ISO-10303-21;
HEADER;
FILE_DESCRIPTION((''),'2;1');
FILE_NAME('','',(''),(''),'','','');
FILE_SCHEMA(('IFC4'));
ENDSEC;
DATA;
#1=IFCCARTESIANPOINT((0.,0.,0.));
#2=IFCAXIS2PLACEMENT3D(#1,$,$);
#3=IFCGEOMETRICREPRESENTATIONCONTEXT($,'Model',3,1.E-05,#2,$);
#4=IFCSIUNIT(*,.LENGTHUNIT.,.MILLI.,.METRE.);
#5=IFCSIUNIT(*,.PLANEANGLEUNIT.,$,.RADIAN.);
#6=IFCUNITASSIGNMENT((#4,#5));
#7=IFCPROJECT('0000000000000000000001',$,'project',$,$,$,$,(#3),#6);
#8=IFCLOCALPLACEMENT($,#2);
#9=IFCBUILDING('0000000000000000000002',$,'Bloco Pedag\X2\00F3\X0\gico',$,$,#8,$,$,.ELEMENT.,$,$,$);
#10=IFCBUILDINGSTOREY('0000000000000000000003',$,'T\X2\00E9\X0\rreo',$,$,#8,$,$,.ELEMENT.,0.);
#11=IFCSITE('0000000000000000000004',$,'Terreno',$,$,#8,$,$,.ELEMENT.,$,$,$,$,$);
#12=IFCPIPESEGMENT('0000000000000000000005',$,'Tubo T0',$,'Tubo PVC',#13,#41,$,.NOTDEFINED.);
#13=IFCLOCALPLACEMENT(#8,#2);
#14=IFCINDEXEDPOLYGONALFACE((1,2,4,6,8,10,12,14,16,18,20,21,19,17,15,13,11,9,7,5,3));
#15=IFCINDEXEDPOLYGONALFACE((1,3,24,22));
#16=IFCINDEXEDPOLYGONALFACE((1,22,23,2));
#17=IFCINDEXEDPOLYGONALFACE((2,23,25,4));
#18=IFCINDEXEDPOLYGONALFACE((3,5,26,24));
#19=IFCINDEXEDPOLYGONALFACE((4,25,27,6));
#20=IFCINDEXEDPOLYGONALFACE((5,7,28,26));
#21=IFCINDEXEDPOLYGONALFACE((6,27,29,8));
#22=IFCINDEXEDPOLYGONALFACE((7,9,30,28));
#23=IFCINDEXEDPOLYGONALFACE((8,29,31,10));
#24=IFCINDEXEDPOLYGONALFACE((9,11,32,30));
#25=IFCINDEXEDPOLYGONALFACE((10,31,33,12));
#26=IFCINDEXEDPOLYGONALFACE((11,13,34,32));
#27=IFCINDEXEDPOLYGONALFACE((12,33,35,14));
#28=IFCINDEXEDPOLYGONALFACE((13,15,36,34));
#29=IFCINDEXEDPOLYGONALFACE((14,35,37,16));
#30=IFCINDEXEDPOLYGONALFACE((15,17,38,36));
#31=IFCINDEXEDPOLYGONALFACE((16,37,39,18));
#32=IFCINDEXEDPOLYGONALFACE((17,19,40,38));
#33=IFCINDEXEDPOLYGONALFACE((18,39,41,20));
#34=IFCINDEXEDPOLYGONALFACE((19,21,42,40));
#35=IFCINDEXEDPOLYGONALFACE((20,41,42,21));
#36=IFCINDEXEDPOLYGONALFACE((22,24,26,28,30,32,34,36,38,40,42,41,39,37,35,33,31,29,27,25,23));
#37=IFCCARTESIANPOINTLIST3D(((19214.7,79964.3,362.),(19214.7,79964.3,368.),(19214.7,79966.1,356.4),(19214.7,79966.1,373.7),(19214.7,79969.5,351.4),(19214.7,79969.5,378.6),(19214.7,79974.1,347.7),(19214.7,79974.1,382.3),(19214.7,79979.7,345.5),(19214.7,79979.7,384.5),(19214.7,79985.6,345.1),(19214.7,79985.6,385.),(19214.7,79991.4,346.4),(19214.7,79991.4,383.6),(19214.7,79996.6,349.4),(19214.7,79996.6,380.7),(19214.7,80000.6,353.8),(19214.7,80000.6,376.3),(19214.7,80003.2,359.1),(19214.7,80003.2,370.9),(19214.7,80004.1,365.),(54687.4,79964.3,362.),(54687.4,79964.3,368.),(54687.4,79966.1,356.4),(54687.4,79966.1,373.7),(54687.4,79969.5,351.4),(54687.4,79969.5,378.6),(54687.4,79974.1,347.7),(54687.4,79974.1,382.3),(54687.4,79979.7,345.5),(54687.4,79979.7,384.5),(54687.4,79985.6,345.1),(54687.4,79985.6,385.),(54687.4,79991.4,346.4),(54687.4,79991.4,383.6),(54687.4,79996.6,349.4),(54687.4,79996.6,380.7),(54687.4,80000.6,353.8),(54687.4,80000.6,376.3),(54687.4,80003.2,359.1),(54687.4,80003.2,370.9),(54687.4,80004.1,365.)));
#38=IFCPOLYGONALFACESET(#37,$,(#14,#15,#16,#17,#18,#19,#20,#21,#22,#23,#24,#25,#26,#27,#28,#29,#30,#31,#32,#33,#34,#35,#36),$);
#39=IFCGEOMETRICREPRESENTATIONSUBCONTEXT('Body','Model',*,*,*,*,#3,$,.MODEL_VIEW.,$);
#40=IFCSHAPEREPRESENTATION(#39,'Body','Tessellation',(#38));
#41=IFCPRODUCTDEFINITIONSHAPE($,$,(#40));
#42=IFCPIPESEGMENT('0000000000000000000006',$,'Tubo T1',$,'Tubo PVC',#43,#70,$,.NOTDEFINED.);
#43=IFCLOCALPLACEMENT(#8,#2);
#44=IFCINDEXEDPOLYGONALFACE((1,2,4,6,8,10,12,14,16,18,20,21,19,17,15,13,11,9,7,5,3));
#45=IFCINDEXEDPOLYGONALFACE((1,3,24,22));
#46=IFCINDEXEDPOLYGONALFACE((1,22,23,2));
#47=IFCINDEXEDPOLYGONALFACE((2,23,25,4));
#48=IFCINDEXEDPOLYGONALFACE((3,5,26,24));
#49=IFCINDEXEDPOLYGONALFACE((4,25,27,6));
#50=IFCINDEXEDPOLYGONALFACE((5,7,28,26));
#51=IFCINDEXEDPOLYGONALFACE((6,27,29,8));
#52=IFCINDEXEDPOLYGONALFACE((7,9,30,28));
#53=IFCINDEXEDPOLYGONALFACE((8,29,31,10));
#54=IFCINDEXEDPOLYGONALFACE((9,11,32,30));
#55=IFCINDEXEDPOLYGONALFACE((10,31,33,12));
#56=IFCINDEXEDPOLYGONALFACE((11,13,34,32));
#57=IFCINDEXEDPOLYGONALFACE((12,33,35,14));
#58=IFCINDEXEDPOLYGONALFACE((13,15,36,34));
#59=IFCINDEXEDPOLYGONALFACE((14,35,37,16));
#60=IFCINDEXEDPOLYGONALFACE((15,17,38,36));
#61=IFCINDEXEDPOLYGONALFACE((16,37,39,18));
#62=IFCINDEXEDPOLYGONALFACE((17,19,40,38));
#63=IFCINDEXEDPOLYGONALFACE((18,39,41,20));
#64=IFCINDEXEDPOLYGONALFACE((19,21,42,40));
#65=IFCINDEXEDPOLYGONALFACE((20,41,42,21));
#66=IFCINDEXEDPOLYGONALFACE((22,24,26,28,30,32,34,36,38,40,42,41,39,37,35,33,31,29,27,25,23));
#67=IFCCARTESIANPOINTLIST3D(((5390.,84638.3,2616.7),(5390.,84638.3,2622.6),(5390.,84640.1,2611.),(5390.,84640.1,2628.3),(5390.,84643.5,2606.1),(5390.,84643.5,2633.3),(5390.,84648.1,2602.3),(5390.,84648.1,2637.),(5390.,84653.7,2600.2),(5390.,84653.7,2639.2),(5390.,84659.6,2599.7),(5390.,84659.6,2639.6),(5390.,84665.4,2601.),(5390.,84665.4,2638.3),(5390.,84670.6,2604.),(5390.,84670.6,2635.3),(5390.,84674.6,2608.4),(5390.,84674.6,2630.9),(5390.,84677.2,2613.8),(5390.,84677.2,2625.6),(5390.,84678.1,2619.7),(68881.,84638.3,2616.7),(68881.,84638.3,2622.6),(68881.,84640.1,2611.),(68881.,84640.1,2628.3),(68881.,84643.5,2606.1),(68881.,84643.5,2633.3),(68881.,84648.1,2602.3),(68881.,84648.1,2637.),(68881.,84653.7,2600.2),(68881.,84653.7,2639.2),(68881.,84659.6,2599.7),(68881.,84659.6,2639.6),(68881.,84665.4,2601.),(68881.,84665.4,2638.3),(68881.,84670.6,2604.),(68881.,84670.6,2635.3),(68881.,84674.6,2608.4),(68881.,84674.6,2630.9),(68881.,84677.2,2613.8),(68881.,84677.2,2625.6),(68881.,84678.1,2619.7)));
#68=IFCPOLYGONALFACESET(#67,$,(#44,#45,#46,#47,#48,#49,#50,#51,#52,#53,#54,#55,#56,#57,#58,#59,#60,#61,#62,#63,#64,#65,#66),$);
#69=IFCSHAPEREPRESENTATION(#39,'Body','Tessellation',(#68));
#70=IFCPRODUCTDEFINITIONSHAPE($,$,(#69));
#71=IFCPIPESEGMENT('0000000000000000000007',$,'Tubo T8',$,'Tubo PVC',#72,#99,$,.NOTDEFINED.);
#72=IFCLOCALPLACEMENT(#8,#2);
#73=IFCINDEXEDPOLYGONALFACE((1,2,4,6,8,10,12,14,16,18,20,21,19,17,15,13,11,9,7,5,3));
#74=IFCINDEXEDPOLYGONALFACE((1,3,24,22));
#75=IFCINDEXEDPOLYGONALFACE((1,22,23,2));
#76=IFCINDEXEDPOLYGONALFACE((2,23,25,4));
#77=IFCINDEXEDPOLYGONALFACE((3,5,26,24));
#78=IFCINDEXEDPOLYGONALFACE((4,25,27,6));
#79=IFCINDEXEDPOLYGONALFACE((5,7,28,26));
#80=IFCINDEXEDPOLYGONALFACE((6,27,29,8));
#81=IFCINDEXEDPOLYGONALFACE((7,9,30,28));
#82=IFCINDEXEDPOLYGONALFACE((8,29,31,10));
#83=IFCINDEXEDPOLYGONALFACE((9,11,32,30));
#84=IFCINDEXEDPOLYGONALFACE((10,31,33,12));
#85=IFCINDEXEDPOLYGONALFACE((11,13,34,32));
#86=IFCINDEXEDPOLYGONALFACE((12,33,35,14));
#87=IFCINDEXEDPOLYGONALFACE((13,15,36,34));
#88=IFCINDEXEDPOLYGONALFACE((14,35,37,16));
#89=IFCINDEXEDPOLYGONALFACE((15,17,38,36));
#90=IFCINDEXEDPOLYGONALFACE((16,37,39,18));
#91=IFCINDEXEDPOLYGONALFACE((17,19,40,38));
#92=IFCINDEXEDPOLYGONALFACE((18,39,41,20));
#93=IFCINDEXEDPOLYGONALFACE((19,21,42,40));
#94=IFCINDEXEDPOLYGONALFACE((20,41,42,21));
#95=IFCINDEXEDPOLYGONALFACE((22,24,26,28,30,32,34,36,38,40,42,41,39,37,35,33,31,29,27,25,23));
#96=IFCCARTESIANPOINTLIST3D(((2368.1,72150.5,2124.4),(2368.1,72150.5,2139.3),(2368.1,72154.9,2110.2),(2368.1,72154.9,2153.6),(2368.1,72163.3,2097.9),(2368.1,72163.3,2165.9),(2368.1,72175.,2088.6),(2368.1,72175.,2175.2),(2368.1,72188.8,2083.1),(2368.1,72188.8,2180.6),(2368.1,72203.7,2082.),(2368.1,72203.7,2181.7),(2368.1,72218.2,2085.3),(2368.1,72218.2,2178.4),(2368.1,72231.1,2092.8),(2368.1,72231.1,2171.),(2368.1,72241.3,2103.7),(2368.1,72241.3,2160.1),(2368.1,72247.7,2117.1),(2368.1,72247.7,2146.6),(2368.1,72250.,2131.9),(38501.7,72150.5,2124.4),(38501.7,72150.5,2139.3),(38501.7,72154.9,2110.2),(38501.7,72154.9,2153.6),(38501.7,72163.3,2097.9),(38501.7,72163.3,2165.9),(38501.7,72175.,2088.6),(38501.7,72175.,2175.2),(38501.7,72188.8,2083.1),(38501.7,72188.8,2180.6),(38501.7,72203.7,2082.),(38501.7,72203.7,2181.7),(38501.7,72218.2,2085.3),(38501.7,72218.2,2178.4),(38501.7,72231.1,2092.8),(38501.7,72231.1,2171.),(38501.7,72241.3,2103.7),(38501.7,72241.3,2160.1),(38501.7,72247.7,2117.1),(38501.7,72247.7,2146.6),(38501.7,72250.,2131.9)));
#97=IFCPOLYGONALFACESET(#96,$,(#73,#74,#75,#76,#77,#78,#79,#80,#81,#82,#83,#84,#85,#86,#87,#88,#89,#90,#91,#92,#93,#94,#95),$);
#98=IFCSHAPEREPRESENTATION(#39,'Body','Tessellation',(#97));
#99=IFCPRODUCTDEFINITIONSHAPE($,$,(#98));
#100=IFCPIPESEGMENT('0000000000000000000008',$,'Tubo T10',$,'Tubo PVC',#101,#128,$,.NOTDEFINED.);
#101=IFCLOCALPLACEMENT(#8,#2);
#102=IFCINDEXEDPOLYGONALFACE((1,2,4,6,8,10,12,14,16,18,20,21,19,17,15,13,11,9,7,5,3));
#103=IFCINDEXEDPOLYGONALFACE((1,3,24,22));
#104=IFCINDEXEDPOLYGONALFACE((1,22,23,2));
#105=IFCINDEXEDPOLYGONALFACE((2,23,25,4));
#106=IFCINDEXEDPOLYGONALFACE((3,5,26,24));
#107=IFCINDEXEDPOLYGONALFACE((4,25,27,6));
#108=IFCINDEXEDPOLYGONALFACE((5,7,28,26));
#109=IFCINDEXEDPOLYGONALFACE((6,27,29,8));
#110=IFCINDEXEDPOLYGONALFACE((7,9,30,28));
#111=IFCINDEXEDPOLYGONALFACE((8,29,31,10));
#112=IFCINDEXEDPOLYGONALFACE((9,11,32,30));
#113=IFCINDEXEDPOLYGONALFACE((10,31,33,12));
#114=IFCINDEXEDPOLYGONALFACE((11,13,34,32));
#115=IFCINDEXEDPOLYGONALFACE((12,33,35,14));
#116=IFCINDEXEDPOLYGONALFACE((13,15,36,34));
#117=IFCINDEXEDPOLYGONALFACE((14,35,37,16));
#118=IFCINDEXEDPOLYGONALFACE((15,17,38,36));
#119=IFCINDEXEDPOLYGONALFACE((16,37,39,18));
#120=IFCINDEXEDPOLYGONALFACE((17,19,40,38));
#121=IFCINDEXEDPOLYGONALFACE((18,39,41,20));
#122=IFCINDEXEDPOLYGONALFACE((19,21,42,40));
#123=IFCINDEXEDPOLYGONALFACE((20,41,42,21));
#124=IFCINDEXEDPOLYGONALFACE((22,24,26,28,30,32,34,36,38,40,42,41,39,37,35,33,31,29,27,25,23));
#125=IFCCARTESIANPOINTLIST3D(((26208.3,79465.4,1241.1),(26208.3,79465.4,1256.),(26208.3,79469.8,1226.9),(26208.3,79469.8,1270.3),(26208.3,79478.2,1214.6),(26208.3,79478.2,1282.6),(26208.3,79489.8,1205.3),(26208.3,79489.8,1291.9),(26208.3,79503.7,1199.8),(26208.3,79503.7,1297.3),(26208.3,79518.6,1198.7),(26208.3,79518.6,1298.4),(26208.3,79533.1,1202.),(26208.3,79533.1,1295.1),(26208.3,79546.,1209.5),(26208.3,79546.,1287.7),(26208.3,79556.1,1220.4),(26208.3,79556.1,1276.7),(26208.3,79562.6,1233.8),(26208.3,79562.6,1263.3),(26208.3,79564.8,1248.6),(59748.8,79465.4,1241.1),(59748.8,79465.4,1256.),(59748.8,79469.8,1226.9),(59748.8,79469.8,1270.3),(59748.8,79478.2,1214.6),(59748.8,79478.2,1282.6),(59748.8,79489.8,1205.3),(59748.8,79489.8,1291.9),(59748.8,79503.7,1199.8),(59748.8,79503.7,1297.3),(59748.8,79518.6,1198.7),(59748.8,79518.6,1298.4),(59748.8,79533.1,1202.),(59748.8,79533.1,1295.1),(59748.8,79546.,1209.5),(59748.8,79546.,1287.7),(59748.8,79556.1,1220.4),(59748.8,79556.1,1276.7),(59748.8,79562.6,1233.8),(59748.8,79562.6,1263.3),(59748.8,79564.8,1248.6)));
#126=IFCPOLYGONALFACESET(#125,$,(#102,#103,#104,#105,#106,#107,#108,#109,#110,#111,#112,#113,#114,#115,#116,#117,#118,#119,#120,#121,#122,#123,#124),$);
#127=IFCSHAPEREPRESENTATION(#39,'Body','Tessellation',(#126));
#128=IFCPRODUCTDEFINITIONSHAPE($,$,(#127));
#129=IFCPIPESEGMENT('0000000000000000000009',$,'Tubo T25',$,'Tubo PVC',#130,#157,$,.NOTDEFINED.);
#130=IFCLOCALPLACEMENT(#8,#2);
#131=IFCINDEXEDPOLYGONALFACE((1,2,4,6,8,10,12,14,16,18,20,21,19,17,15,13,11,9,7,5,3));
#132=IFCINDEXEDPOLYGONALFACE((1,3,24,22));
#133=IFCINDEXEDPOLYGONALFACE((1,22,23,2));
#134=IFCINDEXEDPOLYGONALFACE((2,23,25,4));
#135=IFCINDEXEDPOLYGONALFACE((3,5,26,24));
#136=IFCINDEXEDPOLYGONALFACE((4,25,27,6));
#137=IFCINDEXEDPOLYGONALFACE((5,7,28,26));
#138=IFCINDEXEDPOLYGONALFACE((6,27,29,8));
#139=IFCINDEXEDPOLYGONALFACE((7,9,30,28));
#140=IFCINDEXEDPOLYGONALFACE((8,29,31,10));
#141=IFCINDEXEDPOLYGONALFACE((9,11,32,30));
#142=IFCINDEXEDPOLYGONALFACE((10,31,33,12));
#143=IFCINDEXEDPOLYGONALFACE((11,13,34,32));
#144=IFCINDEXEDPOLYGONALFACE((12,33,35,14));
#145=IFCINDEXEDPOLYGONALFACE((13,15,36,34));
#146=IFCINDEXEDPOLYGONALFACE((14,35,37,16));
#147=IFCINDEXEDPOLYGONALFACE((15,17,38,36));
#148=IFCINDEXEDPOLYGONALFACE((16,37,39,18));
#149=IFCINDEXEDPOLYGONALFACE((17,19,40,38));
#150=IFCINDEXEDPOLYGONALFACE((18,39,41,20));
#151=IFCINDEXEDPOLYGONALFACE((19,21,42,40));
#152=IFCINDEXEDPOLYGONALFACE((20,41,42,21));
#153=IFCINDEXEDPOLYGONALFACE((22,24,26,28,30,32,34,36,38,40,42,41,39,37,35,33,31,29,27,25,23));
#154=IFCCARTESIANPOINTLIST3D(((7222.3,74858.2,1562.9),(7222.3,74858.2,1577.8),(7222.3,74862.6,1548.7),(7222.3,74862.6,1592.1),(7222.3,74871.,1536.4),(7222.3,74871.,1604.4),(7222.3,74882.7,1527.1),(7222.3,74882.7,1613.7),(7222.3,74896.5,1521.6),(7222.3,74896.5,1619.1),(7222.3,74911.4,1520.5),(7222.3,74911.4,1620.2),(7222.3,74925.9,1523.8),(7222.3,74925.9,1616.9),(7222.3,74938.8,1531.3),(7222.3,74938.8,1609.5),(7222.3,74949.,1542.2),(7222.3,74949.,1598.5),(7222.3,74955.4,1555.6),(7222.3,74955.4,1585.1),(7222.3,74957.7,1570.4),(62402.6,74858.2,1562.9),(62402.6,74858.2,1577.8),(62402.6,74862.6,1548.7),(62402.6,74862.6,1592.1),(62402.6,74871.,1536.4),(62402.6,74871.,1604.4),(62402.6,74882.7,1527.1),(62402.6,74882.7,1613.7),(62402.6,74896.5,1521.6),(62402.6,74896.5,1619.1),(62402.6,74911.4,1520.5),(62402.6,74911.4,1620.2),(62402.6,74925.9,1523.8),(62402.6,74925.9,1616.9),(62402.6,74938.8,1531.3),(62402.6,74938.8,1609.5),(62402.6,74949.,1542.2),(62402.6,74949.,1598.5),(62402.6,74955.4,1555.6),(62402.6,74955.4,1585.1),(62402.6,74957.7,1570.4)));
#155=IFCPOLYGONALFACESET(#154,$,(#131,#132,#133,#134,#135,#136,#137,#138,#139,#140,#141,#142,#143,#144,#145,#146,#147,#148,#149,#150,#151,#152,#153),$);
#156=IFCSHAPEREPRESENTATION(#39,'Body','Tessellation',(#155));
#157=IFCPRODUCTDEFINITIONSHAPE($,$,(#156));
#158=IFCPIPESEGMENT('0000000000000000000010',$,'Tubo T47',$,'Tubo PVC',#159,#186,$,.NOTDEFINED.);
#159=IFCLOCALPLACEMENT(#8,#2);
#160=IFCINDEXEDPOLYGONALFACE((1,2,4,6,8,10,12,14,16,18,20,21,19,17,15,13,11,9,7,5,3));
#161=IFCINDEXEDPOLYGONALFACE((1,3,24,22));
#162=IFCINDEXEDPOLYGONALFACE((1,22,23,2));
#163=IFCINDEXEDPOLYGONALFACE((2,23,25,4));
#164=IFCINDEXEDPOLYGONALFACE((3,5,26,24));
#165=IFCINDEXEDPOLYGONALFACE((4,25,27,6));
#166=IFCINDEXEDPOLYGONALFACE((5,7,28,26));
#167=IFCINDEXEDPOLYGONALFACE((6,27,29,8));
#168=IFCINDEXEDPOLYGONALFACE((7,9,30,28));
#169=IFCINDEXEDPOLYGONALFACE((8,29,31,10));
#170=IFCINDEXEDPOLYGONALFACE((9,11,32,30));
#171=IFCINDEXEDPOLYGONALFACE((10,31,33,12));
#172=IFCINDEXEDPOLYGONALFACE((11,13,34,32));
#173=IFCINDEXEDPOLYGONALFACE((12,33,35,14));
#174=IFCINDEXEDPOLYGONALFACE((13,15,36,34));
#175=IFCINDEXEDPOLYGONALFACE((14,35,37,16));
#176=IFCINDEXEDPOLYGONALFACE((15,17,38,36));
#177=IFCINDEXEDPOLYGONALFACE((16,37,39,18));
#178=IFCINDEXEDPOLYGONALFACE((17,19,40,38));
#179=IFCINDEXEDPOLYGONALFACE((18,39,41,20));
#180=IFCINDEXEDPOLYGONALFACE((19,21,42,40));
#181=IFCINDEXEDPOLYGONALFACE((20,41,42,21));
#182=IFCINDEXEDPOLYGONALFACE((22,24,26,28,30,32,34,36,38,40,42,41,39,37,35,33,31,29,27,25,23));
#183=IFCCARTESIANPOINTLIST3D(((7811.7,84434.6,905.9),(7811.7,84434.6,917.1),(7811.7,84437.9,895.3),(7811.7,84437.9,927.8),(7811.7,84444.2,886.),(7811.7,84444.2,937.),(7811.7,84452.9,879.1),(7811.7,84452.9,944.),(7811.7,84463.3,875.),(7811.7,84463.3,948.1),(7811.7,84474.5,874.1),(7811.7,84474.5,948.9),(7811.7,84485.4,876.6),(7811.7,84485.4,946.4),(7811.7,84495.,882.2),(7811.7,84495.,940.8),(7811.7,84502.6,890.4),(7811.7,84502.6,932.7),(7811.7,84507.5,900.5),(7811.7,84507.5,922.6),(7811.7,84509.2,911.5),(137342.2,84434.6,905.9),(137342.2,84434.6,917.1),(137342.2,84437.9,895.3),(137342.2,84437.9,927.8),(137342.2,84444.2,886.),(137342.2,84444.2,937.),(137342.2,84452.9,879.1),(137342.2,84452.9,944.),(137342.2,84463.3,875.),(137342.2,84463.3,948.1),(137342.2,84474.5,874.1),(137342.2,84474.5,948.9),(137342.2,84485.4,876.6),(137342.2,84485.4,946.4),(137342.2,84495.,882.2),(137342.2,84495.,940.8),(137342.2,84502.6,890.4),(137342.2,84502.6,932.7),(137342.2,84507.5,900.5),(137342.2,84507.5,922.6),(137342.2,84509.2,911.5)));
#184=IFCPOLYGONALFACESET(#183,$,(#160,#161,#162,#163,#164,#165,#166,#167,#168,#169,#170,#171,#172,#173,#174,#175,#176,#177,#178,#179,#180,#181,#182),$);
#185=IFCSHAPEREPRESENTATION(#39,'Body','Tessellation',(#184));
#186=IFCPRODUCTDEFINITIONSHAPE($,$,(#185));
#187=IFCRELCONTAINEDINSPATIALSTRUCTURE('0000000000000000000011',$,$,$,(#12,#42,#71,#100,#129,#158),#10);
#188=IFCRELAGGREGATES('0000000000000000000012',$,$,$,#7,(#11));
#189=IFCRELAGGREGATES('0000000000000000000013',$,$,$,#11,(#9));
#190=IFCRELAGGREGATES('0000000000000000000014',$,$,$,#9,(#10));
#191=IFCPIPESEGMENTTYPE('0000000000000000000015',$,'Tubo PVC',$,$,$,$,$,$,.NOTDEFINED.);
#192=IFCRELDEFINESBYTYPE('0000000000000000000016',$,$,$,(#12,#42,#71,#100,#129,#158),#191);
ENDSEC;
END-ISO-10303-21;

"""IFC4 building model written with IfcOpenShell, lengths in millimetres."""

from ifc_helpers import new_model, si_unit, frame, origin, origin_2d, place, context, subcontext, project, spatial, circle, extrude, type_object, element, save


model = new_model("IFC4")

# Units and contexts
model_context = context("Model", 3, precision=1e-05, world=origin())
body_context = subcontext(model_context, "Body", "Model", "MODEL_VIEW")
ifc_project = project(units=[si_unit("LENGTHUNIT", "METRE", prefix="MILLI"), si_unit("PLANEANGLEUNIT", "RADIAN")], contexts=[model_context])

# Site, building, storey
placement = place(None, origin())
site = spatial("IfcSite", under=ifc_project, at=placement, Name="Terreno", CompositionType="ELEMENT")
building = spatial("IfcBuilding", under=site, at=placement, Name="Bloco Pedagógico", CompositionType="ELEMENT")
storey = spatial("IfcBuildingStorey", under=building, at=placement, Name="Térreo", CompositionType="ELEMENT", Elevation=0.0)

# Pipe segments
pipe_segment_type = type_object("IfcPipeSegmentType", Name="Tubo PVC", PredefinedType="NOTDEFINED")
pipe_segment_1_placement = place(None, frame((19214.7, 79984.1, 365.0), z_axis=(1.0, 0.0, 0.0), x_axis=(0.0, 1.0, 0.0)))
element("IfcPipeSegment", 1, at=pipe_segment_1_placement, inside=storey, type_object=pipe_segment_type, Name="Tubo T0", ObjectType="Tubo PVC", PredefinedType="NOTDEFINED", context=body_context, shape_type="SweptSolid", body=[
    extrude(circle(Radius=20.0, at=origin_2d()), None, (0.0, 0.0, 1.0), 35472.7),
])
pipe_segment_2_placement = place(None, frame((5390.0, 84658.1, 2619.7), z_axis=(1.0, 0.0, 0.0), x_axis=(0.0, 1.0, 0.0)))
element("IfcPipeSegment", 2, at=pipe_segment_2_placement, inside=storey, type_object=pipe_segment_type, Name="Tubo T1", ObjectType="Tubo PVC", PredefinedType="NOTDEFINED", context=body_context, shape_type="SweptSolid", body=[
    extrude(circle(Radius=20.0, at=origin_2d()), None, (0.0, 0.0, 1.0), 63491.0),
])
pipe_segment_3_placement = place(None, frame((2368.1, 72200.0, 2131.9), z_axis=(1.0, 0.0, 0.0), x_axis=(0.0, 1.0, 0.0)))
element("IfcPipeSegment", 3, at=pipe_segment_3_placement, inside=storey, type_object=pipe_segment_type, Name="Tubo T8", ObjectType="Tubo PVC", PredefinedType="NOTDEFINED", context=body_context, shape_type="SweptSolid", body=[
    extrude(circle(Radius=50.0, at=origin_2d()), None, (0.0, 0.0, 1.0), 36133.7),
])
pipe_segment_4_placement = place(None, frame((26208.3, 79514.8, 1248.6), z_axis=(1.0, 0.0, 0.0), x_axis=(0.0, 1.0, 0.0)))
element("IfcPipeSegment", 4, at=pipe_segment_4_placement, inside=storey, type_object=pipe_segment_type, Name="Tubo T10", ObjectType="Tubo PVC", PredefinedType="NOTDEFINED", context=body_context, shape_type="SweptSolid", body=[
    extrude(circle(Radius=50.0, at=origin_2d()), None, (0.0, 0.0, 1.0), 33540.5),
])
pipe_segment_5_placement = place(None, frame((7222.3, 74907.7, 1570.4), z_axis=(1.0, 0.0, 0.0), x_axis=(0.0, 1.0, 0.0)))
element("IfcPipeSegment", 5, at=pipe_segment_5_placement, inside=storey, type_object=pipe_segment_type, Name="Tubo T25", ObjectType="Tubo PVC", PredefinedType="NOTDEFINED", context=body_context, shape_type="SweptSolid", body=[
    extrude(circle(Radius=50.0, at=origin_2d()), None, (0.0, 0.0, 1.0), 55180.3),
])
pipe_segment_6_placement = place(None, frame((7811.7, 84471.7, 911.5), z_axis=(1.0, 0.0, 0.0), x_axis=(0.0, 1.0, 0.0)))
element("IfcPipeSegment", 6, at=pipe_segment_6_placement, inside=storey, type_object=pipe_segment_type, Name="Tubo T47", ObjectType="Tubo PVC", PredefinedType="NOTDEFINED", context=body_context, shape_type="SweptSolid", body=[
    extrude(circle(Radius=37.5, at=origin_2d()), None, (0.0, 0.0, 1.0), 129530.5),
])

save(model, "model.ifc")
